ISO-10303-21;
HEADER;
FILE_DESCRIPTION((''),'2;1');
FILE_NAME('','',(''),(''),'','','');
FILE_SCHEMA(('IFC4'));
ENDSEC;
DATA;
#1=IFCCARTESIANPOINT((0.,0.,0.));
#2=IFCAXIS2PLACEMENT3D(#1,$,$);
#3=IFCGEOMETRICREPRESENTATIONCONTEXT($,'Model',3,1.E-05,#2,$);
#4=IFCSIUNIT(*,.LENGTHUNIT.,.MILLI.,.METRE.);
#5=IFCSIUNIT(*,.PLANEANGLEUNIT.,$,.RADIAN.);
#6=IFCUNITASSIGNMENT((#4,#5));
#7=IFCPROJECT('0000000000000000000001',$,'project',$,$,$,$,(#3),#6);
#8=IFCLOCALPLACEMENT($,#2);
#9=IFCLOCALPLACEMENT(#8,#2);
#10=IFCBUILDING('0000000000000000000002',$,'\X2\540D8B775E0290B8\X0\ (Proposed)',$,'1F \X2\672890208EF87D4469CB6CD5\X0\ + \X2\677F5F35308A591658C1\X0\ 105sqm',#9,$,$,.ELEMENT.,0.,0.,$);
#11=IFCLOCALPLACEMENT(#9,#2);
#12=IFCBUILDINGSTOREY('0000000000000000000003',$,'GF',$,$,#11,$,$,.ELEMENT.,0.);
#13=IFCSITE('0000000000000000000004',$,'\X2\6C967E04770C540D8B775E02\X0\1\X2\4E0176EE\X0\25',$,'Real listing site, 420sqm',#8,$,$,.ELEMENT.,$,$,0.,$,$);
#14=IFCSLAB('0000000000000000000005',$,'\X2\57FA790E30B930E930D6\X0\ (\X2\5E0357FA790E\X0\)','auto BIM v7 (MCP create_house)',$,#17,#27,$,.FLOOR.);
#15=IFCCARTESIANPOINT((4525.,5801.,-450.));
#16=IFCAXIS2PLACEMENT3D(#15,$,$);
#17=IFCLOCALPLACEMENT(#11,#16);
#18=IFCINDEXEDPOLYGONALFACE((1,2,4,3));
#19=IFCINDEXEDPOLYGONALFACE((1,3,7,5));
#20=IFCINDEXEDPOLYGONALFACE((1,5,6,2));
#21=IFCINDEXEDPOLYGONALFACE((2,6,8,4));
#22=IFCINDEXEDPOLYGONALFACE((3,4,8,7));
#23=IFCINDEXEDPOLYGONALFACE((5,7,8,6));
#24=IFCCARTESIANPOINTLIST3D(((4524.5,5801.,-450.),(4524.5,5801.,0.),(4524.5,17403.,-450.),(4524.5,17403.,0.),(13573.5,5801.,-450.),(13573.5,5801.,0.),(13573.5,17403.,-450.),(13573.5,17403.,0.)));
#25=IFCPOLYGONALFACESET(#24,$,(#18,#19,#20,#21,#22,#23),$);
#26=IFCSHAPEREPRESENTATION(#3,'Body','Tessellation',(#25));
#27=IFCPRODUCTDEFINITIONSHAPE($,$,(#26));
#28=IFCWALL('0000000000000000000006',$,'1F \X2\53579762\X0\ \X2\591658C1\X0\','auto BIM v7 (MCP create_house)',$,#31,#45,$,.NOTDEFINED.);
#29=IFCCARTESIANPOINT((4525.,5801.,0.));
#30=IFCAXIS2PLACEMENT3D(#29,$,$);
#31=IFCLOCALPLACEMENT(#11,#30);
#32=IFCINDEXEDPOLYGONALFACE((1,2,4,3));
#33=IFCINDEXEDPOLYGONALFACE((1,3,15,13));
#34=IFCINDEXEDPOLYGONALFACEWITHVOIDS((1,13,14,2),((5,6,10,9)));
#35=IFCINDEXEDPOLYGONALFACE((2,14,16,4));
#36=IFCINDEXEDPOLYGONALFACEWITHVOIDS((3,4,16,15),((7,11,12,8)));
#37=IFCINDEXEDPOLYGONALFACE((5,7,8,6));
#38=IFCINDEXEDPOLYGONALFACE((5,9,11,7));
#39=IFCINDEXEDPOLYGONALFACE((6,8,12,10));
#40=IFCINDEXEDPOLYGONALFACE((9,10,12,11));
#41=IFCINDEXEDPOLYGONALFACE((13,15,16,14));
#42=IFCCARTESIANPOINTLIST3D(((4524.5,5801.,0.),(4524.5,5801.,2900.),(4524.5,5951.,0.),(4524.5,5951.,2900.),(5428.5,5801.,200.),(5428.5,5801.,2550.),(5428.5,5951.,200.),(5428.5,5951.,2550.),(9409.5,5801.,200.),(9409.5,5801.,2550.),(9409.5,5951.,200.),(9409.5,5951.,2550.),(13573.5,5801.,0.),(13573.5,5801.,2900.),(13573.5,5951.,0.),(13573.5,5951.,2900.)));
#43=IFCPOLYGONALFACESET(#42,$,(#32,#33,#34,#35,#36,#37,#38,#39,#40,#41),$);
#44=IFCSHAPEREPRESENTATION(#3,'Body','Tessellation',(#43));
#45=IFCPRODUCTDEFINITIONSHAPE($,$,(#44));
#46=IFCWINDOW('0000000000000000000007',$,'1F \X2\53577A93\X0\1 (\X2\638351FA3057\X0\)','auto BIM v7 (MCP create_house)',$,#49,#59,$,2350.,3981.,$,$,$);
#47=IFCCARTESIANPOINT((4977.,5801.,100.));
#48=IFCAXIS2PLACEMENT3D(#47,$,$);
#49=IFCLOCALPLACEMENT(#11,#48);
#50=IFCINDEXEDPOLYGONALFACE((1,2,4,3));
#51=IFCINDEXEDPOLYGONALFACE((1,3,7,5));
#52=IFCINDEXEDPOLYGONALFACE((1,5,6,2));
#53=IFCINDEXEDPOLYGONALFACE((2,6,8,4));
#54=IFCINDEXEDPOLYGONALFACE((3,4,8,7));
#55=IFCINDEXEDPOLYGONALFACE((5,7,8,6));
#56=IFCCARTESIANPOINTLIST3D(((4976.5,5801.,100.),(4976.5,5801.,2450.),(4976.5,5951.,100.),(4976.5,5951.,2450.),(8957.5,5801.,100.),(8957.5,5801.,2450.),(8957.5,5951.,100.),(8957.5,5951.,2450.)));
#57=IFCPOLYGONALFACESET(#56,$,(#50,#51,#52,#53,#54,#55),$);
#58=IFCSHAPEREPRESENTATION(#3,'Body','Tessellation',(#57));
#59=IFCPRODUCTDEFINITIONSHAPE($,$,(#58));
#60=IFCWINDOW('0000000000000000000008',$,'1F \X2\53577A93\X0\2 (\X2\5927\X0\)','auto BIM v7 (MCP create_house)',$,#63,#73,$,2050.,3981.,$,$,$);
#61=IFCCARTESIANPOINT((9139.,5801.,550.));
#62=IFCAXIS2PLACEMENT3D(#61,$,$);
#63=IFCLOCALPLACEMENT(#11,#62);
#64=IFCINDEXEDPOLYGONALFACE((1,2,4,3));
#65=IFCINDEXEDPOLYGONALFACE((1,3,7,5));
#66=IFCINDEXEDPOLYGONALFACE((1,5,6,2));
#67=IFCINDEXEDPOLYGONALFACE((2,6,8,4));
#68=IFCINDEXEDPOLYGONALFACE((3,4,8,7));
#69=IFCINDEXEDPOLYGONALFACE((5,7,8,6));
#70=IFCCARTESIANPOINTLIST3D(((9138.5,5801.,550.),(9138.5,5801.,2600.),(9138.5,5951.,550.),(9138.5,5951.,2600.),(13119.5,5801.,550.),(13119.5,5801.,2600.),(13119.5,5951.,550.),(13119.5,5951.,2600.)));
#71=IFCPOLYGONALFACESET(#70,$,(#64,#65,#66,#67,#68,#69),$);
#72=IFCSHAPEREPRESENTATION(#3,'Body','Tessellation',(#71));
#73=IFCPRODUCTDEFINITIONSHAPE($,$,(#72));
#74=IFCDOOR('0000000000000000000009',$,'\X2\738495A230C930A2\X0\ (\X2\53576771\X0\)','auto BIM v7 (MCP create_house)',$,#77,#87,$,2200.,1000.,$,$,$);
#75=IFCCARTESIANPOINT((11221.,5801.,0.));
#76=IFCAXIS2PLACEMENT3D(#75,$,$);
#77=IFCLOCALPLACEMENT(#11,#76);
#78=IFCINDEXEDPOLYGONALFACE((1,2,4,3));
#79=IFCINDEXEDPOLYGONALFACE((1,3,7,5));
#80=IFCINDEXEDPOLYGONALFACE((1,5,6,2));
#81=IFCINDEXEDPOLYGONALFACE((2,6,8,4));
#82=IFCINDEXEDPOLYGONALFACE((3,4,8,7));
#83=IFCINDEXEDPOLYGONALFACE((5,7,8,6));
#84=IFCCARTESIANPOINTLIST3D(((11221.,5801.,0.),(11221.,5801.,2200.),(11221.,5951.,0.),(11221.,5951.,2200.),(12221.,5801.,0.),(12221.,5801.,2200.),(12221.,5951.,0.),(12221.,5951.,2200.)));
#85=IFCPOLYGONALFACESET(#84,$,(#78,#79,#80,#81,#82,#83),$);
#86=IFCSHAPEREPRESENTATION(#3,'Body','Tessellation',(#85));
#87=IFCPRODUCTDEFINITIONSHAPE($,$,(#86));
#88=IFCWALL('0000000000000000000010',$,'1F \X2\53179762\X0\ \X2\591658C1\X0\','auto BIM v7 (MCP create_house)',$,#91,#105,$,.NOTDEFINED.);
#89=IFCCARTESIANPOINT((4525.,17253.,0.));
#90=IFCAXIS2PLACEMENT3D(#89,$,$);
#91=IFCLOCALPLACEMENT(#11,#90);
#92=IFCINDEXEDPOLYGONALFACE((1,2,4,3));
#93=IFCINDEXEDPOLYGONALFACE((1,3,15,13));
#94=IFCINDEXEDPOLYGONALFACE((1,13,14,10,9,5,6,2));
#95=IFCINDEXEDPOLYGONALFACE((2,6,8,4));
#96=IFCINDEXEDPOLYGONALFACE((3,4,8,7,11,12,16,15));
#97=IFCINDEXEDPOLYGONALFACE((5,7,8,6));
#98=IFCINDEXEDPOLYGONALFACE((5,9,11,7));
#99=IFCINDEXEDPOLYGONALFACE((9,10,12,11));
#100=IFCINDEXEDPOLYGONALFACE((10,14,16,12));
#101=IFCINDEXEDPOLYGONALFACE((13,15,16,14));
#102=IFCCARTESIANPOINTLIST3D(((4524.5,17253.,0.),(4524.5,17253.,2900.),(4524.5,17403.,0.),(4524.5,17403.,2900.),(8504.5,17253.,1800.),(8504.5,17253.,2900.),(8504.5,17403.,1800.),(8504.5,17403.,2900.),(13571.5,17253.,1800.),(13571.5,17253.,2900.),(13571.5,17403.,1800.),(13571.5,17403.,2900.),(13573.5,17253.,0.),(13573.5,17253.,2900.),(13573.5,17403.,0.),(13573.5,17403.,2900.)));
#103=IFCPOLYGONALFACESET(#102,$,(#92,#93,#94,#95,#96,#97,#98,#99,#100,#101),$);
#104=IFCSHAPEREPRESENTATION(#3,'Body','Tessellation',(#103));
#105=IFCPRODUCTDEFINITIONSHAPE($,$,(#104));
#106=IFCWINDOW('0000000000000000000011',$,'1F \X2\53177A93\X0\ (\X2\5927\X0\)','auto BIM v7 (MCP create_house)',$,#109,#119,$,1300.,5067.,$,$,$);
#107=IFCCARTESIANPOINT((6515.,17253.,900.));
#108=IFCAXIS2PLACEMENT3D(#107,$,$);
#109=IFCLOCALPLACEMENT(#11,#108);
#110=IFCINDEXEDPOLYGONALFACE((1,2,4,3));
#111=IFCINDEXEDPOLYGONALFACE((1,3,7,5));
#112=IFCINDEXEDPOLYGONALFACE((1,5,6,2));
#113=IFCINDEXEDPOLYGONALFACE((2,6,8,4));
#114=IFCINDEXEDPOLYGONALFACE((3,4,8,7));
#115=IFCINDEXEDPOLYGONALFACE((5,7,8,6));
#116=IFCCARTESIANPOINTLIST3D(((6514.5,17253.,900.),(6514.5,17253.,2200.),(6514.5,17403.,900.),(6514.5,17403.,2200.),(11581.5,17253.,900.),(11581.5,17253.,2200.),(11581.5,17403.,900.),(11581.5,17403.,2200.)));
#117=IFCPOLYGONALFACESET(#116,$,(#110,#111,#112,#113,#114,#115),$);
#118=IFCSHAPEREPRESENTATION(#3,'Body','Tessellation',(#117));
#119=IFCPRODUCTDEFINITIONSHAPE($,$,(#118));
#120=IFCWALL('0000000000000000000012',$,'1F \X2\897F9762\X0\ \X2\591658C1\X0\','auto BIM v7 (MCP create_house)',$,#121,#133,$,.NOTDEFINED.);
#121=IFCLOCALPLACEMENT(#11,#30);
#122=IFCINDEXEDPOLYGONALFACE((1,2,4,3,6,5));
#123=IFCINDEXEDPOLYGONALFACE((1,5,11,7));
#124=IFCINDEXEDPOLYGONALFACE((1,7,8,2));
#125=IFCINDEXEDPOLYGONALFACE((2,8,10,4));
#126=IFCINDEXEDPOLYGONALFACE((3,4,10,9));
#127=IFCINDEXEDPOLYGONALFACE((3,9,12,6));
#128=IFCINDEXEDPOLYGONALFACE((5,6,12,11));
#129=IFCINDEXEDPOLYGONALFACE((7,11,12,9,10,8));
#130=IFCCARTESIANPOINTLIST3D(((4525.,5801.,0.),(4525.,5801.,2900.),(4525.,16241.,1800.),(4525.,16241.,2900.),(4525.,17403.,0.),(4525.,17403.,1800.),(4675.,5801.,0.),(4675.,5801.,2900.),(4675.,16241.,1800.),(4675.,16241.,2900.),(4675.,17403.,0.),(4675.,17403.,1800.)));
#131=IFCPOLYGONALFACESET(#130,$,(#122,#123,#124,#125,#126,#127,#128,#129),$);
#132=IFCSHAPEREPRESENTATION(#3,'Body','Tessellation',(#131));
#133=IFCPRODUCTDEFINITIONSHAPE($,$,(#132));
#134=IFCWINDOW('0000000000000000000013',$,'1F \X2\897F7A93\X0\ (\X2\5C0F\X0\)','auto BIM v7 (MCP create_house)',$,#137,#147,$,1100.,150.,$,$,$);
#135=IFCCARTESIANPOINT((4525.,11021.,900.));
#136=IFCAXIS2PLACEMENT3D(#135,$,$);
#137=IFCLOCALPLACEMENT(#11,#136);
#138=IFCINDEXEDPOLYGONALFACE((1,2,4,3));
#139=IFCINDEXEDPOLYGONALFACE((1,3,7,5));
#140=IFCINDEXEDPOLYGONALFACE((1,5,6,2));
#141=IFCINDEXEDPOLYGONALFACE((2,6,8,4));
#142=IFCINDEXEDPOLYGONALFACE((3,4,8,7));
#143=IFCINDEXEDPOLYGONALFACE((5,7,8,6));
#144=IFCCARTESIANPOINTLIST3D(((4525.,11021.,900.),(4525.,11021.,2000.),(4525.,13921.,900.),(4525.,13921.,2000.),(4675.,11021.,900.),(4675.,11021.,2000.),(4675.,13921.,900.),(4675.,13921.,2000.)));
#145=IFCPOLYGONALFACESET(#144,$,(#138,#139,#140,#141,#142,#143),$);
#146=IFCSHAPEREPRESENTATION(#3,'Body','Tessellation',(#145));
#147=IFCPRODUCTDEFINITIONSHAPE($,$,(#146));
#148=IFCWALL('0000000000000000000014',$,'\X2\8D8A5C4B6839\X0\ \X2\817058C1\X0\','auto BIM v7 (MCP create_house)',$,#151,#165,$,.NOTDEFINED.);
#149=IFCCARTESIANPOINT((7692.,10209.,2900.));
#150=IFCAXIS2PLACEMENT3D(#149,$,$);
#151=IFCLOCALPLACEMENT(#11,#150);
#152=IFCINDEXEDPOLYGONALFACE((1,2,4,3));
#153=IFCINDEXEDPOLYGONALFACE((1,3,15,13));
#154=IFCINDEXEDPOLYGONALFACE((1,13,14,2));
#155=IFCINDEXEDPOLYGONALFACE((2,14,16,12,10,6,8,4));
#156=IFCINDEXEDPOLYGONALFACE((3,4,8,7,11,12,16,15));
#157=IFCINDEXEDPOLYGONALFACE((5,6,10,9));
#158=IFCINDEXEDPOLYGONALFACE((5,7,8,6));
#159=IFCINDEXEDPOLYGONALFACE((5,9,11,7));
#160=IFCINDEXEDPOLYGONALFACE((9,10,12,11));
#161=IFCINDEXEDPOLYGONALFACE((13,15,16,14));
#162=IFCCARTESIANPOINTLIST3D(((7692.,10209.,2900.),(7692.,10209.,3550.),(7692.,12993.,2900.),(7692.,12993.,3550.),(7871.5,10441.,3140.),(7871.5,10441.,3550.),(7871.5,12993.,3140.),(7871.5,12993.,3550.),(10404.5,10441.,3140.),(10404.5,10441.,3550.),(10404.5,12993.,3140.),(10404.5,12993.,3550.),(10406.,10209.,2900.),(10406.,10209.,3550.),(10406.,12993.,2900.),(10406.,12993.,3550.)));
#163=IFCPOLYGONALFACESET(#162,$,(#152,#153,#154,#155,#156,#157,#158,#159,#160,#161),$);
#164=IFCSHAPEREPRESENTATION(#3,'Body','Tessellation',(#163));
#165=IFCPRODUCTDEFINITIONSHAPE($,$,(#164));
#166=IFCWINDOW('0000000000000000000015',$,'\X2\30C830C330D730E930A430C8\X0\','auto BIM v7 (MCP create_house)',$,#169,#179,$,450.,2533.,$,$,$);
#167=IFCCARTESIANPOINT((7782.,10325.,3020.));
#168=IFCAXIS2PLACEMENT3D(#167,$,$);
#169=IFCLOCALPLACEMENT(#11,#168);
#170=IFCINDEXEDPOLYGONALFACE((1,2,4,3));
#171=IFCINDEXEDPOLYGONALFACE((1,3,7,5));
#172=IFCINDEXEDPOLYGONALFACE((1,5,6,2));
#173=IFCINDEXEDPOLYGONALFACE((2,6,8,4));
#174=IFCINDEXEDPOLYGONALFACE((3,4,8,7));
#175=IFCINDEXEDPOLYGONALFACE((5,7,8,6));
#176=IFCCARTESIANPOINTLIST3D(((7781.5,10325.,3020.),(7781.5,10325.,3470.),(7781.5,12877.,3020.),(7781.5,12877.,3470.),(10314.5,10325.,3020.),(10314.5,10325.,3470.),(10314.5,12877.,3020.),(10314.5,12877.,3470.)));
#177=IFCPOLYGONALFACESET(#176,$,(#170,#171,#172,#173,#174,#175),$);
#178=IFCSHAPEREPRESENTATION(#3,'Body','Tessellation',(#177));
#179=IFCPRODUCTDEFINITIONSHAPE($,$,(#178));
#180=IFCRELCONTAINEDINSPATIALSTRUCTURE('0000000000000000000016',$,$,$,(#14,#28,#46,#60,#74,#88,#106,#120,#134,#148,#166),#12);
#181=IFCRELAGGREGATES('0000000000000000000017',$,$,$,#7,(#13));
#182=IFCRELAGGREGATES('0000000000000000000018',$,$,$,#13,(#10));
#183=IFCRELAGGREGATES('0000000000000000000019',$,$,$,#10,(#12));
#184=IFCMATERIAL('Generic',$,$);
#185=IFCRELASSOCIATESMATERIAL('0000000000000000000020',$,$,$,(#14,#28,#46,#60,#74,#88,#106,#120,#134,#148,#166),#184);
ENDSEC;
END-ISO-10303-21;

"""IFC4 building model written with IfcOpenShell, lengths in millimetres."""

from ifc_helpers import new_model, si_unit, frame, frame_2d, origin, place, context, project, spatial, rectangle, extrude, material, element, fill, save


model = new_model("IFC4")

# Units and contexts
model_context = context("Model", 3, precision=1e-05, world=origin())
ifc_project = project(units=[si_unit("LENGTHUNIT", "METRE", prefix="MILLI"), si_unit("PLANEANGLEUNIT", "RADIAN")], contexts=[model_context])

# Site, building, storey
site_placement = place(None, origin())
site = spatial("IfcSite", under=ifc_project, at=site_placement, Name="沖縄県名護市1丁目25", ObjectType="Real listing site, 420sqm", CompositionType="ELEMENT", RefElevation=0.0)
building_placement = place(site_placement, origin())
building = spatial("IfcBuilding", under=site, at=building_placement, Name="名護市邸 (Proposed)", ObjectType="1F 木造軸組構法 + 板張り外壁 105sqm", CompositionType="ELEMENT", ElevationOfRefHeight=0.0, ElevationOfTerrain=0.0)
storey_placement = place(building_placement, origin())
storey = spatial("IfcBuildingStorey", under=building, at=storey_placement, Name="GF", CompositionType="ELEMENT", Elevation=0.0)

# Slab
ifc_material = material(Name="Generic")
slab_1_placement = place(storey_placement, frame((4525.0, 5801.0, -450.0)))
element("IfcSlab", 1, at=slab_1_placement, inside=storey, material=ifc_material, Name="基礎スラブ (布基礎)", Description="auto BIM v7 (MCP create_house)", PredefinedType="FLOOR", context=model_context, shape_type="SweptSolid", body=[
    extrude(rectangle(XDim=9049.0, YDim=11602.0, at=frame_2d((4524.0, 5801.0))), frame((4525.0, 5801.0, -450.0)), (0.0, 0.0, 1.0), 450.0),
])

# Wall, openings, windows, door
wall_1_placement = place(storey_placement, frame((4525.0, 5801.0, 0.0)))
wall_1 = element("IfcWall", 2, at=wall_1_placement, inside=storey, material=ifc_material, Name="1F 南面 外壁", Description="auto BIM v7 (MCP create_house)", PredefinedType="NOTDEFINED", context=model_context, shape_type="SweptSolid", body=[
    extrude(rectangle(XDim=9049.0, YDim=150.0, at=frame_2d((4524.0, 75.0))), frame((4525.0, 5801.0, 0.0)), (0.0, 0.0, 1.0), 2900.0),
])
opening_1_placement = place(storey_placement, frame((4977.0, 5801.0, 100.0)))
opening_1 = element("IfcOpeningElement", 3, at=opening_1_placement, cuts=wall_1, PredefinedType="NOTDEFINED", context=model_context, shape_type="SweptSolid", body=[
    extrude(rectangle(XDim=3981.0, YDim=150.0, at=frame_2d((1990.0, 75.0))), frame((4977.0, 5801.0, 100.0)), (0.0, 0.0, 1.0), 2350.0),
])
opening_2_placement = place(storey_placement, frame((9139.0, 5801.0, 550.0)))
opening_2 = element("IfcOpeningElement", 4, at=opening_2_placement, cuts=wall_1, PredefinedType="NOTDEFINED", context=model_context, shape_type="SweptSolid", body=[
    extrude(rectangle(XDim=3981.0, YDim=150.0, at=frame_2d((1990.0, 75.0))), frame((9139.0, 5801.0, 550.0)), (0.0, 0.0, 1.0), 2050.0),
])
opening_3_placement = place(storey_placement, frame((11221.0, 5801.0, 0.0)))
opening_3 = element("IfcOpeningElement", 5, at=opening_3_placement, cuts=wall_1, PredefinedType="NOTDEFINED", context=model_context, shape_type="SweptSolid", body=[
    extrude(rectangle(XDim=1000.0, YDim=150.0, at=frame_2d((500.0, 75.0))), frame((11221.0, 5801.0, 0.0)), (0.0, 0.0, 1.0), 2200.0),
])
window_1_placement = place(storey_placement, frame((4977.0, 5801.0, 100.0)))
window_1 = element("IfcWindow", 6, at=window_1_placement, inside=storey, material=ifc_material, Name="1F 南窓1 (掃出し)", Description="auto BIM v7 (MCP create_house)", OverallHeight=2350.0, OverallWidth=3981.0, context=model_context, shape_type="SweptSolid", body=[
    extrude(rectangle(XDim=3981.0, YDim=150.0, at=frame_2d((1990.0, 75.0))), frame((4977.0, 5801.0, 100.0)), (0.0, 0.0, 1.0), 2350.0),
])
fill(opening_1, window_1)
window_2_placement = place(storey_placement, frame((9139.0, 5801.0, 550.0)))
window_2 = element("IfcWindow", 7, at=window_2_placement, inside=storey, material=ifc_material, Name="1F 南窓2 (大)", Description="auto BIM v7 (MCP create_house)", OverallHeight=2050.0, OverallWidth=3981.0, context=model_context, shape_type="SweptSolid", body=[
    extrude(rectangle(XDim=3981.0, YDim=150.0, at=frame_2d((1990.0, 75.0))), frame((9139.0, 5801.0, 550.0)), (0.0, 0.0, 1.0), 2050.0),
])
fill(opening_2, window_2)
door_placement = place(storey_placement, frame((11221.0, 5801.0, 0.0)))
door = element("IfcDoor", 8, at=door_placement, inside=storey, material=ifc_material, Name="玄関ドア (南東)", Description="auto BIM v7 (MCP create_house)", OverallHeight=2200.0, OverallWidth=1000.0, context=model_context, shape_type="SweptSolid", body=[
    extrude(rectangle(XDim=1000.0, YDim=150.0, at=frame_2d((500.0, 75.0))), frame((11221.0, 5801.0, 0.0)), (0.0, 0.0, 1.0), 2200.0),
])
fill(opening_3, door)

# Walls, openings, windows
wall_2_placement = place(storey_placement, frame((4525.0, 17253.0, 0.0)))
wall_2 = element("IfcWall", 9, at=wall_2_placement, inside=storey, material=ifc_material, Name="1F 北面 外壁", Description="auto BIM v7 (MCP create_house)", PredefinedType="NOTDEFINED", context=model_context, shape_type="SweptSolid", body=[
    extrude(rectangle(XDim=9049.0, YDim=150.0, at=frame_2d((4524.0, 75.0))), frame((4525.0, 17253.0, 0.0)), (0.0, 0.0, 1.0), 2900.0),
])
opening_4_placement = place(storey_placement, frame((6515.0, 17253.0, 900.0)))
opening_4 = element("IfcOpeningElement", 10, at=opening_4_placement, cuts=wall_2, PredefinedType="NOTDEFINED", context=model_context, shape_type="SweptSolid", body=[
    extrude(rectangle(XDim=5067.0, YDim=150.0, at=frame_2d((2533.0, 75.0))), frame((6515.0, 17253.0, 900.0)), (0.0, 0.0, 1.0), 1300.0),
])
window_3_placement = place(storey_placement, frame((6515.0, 17253.0, 900.0)))
window_3 = element("IfcWindow", 11, at=window_3_placement, inside=storey, material=ifc_material, Name="1F 北窓 (大)", Description="auto BIM v7 (MCP create_house)", OverallHeight=1300.0, OverallWidth=5067.0, context=model_context, shape_type="SweptSolid", body=[
    extrude(rectangle(XDim=5067.0, YDim=150.0, at=frame_2d((2533.0, 75.0))), frame((6515.0, 17253.0, 900.0)), (0.0, 0.0, 1.0), 1300.0),
])
fill(opening_4, window_3)
wall_3_placement = place(storey_placement, frame((4525.0, 5801.0, 0.0)))
wall_3 = element("IfcWall", 12, at=wall_3_placement, inside=storey, material=ifc_material, Name="1F 西面 外壁", Description="auto BIM v7 (MCP create_house)", PredefinedType="NOTDEFINED", context=model_context, shape_type="SweptSolid", body=[
    extrude(rectangle(XDim=150.0, YDim=11602.0, at=frame_2d((75.0, 5801.0))), frame((4525.0, 5801.0, 0.0)), (0.0, 0.0, 1.0), 2900.0),
])
opening_5_placement = place(storey_placement, frame((4525.0, 11021.0, 900.0)))
opening_5 = element("IfcOpeningElement", 13, at=opening_5_placement, cuts=wall_3, PredefinedType="NOTDEFINED", context=model_context, shape_type="SweptSolid", body=[
    extrude(rectangle(XDim=150.0, YDim=2900.0, at=frame_2d((75.0, 1450.0))), frame((4525.0, 11021.0, 900.0)), (0.0, 0.0, 1.0), 1100.0),
])
window_4_placement = place(storey_placement, frame((4525.0, 11021.0, 900.0)))
window_4 = element("IfcWindow", 14, at=window_4_placement, inside=storey, material=ifc_material, Name="1F 西窓 (小)", Description="auto BIM v7 (MCP create_house)", OverallHeight=1100.0, OverallWidth=150.0, context=model_context, shape_type="SweptSolid", body=[
    extrude(rectangle(XDim=150.0, YDim=2900.0, at=frame_2d((75.0, 1450.0))), frame((4525.0, 11021.0, 900.0)), (0.0, 0.0, 1.0), 1100.0),
])
fill(opening_5, window_4)

# Wall, opening, window
wall_4_placement = place(storey_placement, frame((7692.0, 10209.0, 2900.0)))
wall_4 = element("IfcWall", 15, at=wall_4_placement, inside=storey, material=ifc_material, Name="越屋根 腰壁", Description="auto BIM v7 (MCP create_house)", PredefinedType="NOTDEFINED", context=model_context, shape_type="SweptSolid", body=[
    extrude(rectangle(XDim=2714.0, YDim=2784.0, at=frame_2d((1357.0, 1392.0))), frame((7692.0, 10209.0, 2900.0)), (0.0, 0.0, 1.0), 650.0),
])
opening_6_placement = place(storey_placement, frame((7782.0, 10325.0, 3020.0)))
opening_6 = element("IfcOpeningElement", 16, at=opening_6_placement, cuts=wall_4, PredefinedType="NOTDEFINED", context=model_context, shape_type="SweptSolid", body=[
    extrude(rectangle(XDim=2533.0, YDim=2552.0, at=frame_2d((1266.0, 1276.0))), frame((7782.0, 10325.0, 3020.0)), (0.0, 0.0, 1.0), 450.0),
])
window_5_placement = place(storey_placement, frame((7782.0, 10325.0, 3020.0)))
window_5 = element("IfcWindow", 17, at=window_5_placement, inside=storey, material=ifc_material, Name="トップライト", Description="auto BIM v7 (MCP create_house)", OverallHeight=450.0, OverallWidth=2533.0, context=model_context, shape_type="SweptSolid", body=[
    extrude(rectangle(XDim=2533.0, YDim=2552.0, at=frame_2d((1266.0, 1276.0))), frame((7782.0, 10325.0, 3020.0)), (0.0, 0.0, 1.0), 450.0),
])
fill(opening_6, window_5)

save(model, "model.ifc")
